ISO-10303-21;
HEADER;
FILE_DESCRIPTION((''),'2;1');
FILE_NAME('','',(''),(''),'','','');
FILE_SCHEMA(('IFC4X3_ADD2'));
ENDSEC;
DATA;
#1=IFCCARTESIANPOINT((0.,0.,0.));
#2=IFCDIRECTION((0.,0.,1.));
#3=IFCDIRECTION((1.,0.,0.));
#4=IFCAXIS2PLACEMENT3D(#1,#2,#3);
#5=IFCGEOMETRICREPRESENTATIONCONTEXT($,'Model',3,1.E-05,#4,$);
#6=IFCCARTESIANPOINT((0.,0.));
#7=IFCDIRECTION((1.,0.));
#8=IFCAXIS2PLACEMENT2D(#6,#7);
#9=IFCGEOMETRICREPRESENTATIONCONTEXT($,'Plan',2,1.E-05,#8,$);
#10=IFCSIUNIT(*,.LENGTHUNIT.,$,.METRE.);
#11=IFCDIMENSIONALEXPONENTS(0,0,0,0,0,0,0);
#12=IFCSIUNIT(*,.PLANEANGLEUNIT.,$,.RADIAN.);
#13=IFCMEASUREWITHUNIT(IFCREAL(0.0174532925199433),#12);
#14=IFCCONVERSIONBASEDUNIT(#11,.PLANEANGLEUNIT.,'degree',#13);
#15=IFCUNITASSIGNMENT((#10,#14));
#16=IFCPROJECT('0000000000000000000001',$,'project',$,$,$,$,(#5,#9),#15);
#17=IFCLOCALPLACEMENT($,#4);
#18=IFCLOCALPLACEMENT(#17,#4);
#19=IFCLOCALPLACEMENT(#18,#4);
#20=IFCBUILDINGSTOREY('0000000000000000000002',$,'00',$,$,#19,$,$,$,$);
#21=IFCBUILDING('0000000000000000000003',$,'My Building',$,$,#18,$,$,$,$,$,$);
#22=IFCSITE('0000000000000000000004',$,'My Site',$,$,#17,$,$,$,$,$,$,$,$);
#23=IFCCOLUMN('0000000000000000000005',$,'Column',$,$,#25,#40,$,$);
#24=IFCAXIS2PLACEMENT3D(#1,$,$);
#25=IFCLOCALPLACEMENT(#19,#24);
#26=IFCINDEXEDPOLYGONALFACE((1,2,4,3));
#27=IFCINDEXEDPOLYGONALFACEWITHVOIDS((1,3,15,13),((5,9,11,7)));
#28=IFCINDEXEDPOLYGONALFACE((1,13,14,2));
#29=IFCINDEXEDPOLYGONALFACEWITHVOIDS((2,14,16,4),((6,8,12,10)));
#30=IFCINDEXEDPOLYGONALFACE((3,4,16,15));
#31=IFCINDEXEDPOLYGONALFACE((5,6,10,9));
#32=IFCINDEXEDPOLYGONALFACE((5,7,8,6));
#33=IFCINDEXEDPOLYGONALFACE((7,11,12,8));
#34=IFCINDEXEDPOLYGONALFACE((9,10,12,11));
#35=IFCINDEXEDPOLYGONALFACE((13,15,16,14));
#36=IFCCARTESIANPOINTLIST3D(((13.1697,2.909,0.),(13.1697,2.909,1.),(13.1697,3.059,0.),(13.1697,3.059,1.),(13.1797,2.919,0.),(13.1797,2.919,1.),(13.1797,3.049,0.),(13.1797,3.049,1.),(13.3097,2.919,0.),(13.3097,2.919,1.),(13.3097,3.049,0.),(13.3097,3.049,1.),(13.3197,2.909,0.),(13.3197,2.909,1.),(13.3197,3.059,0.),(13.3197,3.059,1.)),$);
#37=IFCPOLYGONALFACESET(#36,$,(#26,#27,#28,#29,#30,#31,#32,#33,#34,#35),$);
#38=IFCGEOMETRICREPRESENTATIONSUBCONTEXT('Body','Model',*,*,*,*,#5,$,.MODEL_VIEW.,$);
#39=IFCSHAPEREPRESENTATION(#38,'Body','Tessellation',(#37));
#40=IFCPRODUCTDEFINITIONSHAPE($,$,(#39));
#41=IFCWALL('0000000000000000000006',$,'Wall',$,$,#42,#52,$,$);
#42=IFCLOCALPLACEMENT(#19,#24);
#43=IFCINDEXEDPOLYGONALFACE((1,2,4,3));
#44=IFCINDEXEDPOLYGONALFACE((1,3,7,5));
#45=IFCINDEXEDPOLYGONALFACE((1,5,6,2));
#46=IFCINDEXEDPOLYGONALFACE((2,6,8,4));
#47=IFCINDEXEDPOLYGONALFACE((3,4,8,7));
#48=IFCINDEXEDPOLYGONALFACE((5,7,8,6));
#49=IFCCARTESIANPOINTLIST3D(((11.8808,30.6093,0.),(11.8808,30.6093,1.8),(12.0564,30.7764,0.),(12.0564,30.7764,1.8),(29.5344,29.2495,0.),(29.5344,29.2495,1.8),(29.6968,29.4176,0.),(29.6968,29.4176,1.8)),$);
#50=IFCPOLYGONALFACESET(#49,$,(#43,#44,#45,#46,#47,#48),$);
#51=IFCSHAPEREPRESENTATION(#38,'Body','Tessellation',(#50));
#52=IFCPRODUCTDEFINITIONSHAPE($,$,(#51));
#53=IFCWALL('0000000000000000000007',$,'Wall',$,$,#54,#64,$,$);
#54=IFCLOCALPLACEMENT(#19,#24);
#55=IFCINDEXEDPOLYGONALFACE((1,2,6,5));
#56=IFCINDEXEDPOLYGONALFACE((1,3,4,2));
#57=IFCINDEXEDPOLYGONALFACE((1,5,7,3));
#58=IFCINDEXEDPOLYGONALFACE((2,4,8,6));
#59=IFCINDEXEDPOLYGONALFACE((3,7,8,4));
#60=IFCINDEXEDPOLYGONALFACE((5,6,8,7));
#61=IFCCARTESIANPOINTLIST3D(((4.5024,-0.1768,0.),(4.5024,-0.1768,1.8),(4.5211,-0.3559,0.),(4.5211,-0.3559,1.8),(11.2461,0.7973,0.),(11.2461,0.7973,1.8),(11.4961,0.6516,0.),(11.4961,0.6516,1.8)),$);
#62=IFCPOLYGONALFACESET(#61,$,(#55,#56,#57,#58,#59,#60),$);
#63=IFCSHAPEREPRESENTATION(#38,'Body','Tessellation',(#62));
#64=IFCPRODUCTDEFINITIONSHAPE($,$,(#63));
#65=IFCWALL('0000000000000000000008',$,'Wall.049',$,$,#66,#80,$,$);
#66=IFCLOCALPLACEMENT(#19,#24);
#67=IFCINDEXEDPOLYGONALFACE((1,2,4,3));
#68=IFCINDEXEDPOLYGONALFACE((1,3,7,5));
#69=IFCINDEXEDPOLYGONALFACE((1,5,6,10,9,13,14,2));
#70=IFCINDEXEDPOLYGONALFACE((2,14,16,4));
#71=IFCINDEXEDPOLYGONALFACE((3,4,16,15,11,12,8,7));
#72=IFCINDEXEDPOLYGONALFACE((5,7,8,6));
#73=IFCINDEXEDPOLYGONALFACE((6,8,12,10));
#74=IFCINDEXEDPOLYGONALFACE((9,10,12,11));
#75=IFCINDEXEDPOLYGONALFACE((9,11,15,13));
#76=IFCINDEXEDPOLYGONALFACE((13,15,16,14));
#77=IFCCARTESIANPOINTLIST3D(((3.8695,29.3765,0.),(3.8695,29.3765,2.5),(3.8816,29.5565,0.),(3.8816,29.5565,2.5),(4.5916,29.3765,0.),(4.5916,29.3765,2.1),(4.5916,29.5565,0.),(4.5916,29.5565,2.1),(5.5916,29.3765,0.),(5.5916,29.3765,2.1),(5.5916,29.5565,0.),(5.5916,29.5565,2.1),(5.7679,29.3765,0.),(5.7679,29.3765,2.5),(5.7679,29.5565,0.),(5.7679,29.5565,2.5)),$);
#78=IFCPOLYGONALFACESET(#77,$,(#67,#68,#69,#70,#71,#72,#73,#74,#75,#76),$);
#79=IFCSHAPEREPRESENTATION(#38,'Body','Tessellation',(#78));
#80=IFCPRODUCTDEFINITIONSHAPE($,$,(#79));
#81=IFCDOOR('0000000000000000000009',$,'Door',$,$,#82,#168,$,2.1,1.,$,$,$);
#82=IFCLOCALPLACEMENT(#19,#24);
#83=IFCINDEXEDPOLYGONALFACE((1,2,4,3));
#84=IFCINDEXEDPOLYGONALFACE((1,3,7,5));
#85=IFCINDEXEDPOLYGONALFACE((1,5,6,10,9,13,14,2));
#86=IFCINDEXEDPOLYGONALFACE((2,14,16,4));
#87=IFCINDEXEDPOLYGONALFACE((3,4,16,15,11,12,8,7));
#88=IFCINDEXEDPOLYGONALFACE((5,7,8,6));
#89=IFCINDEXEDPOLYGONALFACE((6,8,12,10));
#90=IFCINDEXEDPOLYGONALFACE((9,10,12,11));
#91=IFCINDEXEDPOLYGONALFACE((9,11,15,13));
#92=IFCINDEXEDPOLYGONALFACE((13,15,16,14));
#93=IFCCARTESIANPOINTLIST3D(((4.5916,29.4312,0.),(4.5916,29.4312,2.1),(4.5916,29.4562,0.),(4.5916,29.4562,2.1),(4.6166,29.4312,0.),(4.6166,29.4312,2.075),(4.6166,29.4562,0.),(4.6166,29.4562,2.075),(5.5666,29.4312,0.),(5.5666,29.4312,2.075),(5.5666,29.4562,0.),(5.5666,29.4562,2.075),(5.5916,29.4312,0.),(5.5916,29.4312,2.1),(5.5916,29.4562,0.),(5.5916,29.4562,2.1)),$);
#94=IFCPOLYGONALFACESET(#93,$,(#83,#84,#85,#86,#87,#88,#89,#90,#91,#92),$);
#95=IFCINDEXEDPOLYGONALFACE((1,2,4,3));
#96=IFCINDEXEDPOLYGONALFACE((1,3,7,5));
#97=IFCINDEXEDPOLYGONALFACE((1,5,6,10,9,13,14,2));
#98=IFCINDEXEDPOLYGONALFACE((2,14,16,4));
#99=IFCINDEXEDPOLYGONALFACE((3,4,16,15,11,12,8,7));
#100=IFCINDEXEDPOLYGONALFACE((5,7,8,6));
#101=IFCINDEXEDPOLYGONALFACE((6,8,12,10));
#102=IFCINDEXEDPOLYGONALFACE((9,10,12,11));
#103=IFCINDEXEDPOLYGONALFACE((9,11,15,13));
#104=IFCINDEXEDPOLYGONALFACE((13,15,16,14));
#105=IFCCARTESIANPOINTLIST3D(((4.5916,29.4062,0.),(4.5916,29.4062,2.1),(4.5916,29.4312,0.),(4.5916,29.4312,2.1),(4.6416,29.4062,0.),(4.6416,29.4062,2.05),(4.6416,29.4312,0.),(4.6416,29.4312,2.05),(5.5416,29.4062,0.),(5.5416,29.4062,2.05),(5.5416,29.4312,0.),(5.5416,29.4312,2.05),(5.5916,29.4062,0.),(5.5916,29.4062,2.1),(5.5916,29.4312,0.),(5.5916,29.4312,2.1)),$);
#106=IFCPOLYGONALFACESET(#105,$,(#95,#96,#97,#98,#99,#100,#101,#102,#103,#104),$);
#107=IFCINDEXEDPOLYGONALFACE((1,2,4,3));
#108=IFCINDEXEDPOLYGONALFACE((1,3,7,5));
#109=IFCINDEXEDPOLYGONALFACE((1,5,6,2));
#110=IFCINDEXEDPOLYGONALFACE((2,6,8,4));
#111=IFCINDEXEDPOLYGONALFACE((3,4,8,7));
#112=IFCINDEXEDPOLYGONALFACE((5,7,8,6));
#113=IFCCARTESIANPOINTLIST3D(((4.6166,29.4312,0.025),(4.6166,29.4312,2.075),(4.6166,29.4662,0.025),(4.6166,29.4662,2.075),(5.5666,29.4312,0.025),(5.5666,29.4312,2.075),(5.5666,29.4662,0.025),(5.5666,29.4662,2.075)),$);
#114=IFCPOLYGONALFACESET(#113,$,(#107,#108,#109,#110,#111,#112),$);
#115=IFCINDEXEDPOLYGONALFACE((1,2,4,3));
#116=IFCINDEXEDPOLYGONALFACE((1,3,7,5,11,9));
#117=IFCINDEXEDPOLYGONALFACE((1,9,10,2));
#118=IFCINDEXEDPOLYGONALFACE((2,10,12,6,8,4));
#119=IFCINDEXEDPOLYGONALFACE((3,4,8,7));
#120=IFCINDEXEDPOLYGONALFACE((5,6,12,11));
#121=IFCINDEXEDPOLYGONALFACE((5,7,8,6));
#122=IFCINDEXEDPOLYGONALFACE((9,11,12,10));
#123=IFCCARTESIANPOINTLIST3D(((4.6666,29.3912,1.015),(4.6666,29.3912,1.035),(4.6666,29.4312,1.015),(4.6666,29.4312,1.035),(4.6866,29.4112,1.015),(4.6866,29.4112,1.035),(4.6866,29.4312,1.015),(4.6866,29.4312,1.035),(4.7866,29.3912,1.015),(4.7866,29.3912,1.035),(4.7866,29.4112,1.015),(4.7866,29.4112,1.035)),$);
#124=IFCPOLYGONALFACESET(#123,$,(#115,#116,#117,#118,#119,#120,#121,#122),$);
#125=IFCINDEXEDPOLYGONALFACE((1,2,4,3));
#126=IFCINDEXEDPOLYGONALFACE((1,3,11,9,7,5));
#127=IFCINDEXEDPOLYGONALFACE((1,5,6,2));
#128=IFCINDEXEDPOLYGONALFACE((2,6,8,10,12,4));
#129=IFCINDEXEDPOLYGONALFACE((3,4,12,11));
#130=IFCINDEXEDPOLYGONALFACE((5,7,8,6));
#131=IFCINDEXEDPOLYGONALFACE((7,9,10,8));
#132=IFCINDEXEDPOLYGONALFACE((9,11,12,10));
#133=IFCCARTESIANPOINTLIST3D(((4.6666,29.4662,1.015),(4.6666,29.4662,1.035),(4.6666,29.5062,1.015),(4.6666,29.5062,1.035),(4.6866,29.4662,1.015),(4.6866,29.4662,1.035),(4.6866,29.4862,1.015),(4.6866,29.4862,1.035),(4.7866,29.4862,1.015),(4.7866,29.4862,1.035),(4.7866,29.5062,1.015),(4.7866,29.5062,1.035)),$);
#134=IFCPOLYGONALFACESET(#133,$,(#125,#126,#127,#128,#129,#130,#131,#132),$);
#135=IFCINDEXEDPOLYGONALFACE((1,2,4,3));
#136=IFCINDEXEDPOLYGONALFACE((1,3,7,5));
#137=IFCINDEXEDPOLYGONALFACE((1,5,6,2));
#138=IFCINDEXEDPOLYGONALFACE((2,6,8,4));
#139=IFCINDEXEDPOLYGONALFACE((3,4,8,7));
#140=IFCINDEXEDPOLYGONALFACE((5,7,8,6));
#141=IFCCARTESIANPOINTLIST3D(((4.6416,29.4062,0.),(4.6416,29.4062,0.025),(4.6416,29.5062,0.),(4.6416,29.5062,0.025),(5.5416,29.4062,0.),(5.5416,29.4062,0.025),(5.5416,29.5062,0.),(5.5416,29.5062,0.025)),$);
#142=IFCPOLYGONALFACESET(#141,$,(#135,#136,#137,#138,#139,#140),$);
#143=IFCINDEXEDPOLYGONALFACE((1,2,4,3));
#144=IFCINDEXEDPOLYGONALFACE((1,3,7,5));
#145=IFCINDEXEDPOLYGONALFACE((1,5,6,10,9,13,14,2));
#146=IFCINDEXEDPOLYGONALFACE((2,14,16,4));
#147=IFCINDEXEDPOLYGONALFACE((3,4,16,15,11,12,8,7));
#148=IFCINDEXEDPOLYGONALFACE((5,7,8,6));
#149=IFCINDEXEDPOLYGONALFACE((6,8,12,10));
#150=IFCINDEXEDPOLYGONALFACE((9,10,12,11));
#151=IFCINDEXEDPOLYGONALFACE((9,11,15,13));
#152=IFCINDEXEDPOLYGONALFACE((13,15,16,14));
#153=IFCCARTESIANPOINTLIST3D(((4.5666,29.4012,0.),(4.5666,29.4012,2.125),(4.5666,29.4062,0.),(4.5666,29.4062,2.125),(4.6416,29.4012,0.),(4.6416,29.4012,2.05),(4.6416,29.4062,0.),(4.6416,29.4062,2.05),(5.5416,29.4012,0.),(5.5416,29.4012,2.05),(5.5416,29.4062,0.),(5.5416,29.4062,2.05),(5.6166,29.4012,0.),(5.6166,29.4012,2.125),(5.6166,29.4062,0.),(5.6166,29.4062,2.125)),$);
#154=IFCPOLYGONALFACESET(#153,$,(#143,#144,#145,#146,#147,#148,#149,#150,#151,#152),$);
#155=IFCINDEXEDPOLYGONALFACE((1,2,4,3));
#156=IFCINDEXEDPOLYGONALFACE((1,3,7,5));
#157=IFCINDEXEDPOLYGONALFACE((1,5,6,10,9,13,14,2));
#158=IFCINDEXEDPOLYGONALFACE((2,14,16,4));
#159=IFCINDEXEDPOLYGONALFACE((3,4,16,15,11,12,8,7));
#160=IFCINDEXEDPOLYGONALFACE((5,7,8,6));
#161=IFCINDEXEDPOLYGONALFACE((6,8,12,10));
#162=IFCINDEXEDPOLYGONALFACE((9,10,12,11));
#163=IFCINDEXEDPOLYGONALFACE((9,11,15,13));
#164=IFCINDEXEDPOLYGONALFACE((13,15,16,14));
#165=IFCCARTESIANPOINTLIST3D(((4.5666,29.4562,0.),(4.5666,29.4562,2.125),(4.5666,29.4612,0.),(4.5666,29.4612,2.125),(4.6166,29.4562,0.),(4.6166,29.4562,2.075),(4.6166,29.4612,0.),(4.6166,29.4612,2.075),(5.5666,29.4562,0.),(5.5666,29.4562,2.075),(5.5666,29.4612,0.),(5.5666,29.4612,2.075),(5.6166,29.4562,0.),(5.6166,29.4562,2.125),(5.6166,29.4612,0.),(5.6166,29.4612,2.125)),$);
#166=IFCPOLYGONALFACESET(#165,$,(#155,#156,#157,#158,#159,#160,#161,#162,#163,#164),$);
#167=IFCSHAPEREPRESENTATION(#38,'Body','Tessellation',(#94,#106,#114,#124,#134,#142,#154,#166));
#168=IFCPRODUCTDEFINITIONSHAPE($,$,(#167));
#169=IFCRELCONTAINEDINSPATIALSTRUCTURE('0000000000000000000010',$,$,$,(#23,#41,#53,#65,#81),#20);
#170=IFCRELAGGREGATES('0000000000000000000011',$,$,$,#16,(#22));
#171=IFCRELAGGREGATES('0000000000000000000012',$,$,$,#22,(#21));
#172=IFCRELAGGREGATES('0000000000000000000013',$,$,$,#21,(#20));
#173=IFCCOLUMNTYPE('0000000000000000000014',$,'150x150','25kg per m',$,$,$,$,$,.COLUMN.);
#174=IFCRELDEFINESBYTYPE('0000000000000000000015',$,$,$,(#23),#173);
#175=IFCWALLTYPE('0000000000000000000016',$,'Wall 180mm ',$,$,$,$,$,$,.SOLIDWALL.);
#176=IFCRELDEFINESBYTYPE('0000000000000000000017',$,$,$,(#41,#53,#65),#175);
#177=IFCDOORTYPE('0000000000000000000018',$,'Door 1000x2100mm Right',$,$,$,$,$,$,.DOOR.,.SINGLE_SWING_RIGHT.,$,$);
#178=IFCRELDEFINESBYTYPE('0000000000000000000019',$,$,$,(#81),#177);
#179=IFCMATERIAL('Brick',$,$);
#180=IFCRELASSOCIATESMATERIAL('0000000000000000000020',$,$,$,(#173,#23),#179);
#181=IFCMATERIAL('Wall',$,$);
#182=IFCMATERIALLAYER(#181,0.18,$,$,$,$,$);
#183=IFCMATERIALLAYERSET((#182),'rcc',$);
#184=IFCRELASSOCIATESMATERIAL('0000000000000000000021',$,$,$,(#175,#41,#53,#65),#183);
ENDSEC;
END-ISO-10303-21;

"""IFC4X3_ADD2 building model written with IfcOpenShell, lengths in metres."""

from ifc_helpers import new_model, entity, si_unit, converted_unit, frame, origin_with_axes, origin_2d_with_axis, place, context, subcontext, project, spatial, line, indexed_curve, hollow_rectangle, outline, extrude, clip, halfspace, shape, source, transform, mapped, material, layer, layer_set, layer_usage, material_profile, profile_set, profile_usage, type_object, type_shapes, element, fill, save


model = new_model("IFC4X3_ADD2")

# Units and contexts
model_context = context("Model", 3, precision=1e-05, world=origin_with_axes())
plan_context = context("Plan", 2, precision=1e-05, world=origin_2d_with_axis())
body_context_1 = subcontext(model_context, "Body", "Model", "MODEL_VIEW")
body_context_2 = subcontext(plan_context, "Body", "Plan", "PLAN_VIEW")
ifc_project = project(units=[si_unit("LENGTHUNIT", "METRE"), converted_unit("PLANEANGLEUNIT", "degree", entity("IfcReal", 0.0174532925199433), si_unit("PLANEANGLEUNIT", "RADIAN"), dimensions=[0, 0, 0, 0, 0, 0, 0])], contexts=[model_context, plan_context])

# Site, building, storey
site_placement = place(None, origin_with_axes())
site = spatial("IfcSite", under=ifc_project, at=site_placement, Name="My Site")
building_placement = place(site_placement, origin_with_axes())
building = spatial("IfcBuilding", under=site, at=building_placement, Name="My Building")
storey_placement = place(building_placement, origin_with_axes())
storey = spatial("IfcBuildingStorey", under=building, at=storey_placement, Name="00")

# Column
ifc_material_1 = material(Name="Brick")
ifc_material_profile = material_profile(ifc_material_1, hollow_rectangle(XDim=0.15, YDim=0.15, WallThickness=0.01))
ifc_profile_set = profile_set([ifc_material_profile])
ifc_profile_usage = profile_usage(ifc_profile_set, cardinal=5)
column_type = type_object("IfcColumnType", Name="150x150", Description="25kg per m", PredefinedType="COLUMN", material=ifc_profile_set)
column_placement = place(storey_placement, frame((13.2447, 2.984, 0.0), z_axis=(0.0, 0.0, 1.0), x_axis=(1.0, 0.0, 0.0)))
element("IfcColumn", 1, at=column_placement, inside=storey, type_object=column_type, material=ifc_profile_usage, Name="Column", shapes=[
    shape(body_context_1, "Body", "SweptSolid", [extrude(hollow_rectangle(XDim=0.15, YDim=0.15, WallThickness=0.01), origin_with_axes(), (0.0, 0.0, 1.0), 1.0)]),
    shape(body_context_2, "Body", "Annotation2D", [entity("IfcGeometricCurveSet", [entity("IfcIndexedPolyCurve", entity("IfcCartesianPointList2D", [[-0.065, -0.065], [-0.065, 0.065], [0.065, 0.065], [0.065, -0.065]]), [entity("IfcLineIndex", [1, 2, 3, 4, 1])]), entity("IfcIndexedPolyCurve", entity("IfcCartesianPointList2D", [[0.075, -0.075], [-0.075, -0.075], [-0.075, 0.075], [0.075, 0.075]]), [entity("IfcLineIndex", [1, 2, 3, 4, 1])])])]),
])

# Walls
ifc_material_2 = material(Name="Wall")
ifc_layer_1 = layer(ifc_material_2, 0.18)
ifc_layer_set_1 = layer_set([ifc_layer_1], Name="rcc")
wall_type_1 = type_object("IfcWallType", Name="Wall 180mm ", PredefinedType="SOLIDWALL", material=ifc_layer_set_1)
ifc_layer_usage_1 = layer_usage(ifc_layer_set_1, "AXIS2", "POSITIVE", 0.0)
wall_1_placement = place(storey_placement, frame((29.6968, 29.4176, 0.0), z_axis=(0.0, 0.0, 1.0), x_axis=(-0.997047, 0.076799, 0.0)))
element("IfcWall", 2, at=wall_1_placement, inside=storey, type_object=wall_type_1, material=ifc_layer_usage_1, Name="Wall", context=body_context_1, shape_type="SweptSolid", body=[
    extrude(outline(indexed_curve([(0.0, 0.0), (0.149, 0.18), (17.8549, 0.18), (17.6927, 0.0)], segments=[line(1, 2, 3, 4, 1)])), origin_with_axes(), (0.0, 0.0, 1.0), 1.8),
])
ifc_layer_usage_2 = layer_usage(ifc_layer_set_1, "AXIS2", "POSITIVE", 0.0)
wall_2_placement = place(storey_placement, frame((4.5211, -0.3559, 0.0), z_axis=(0.0, 0.0, 1.0), x_axis=(0.989728, 0.142965, 0.0)))
element("IfcWall", 3, at=wall_2_placement, inside=storey, type_object=wall_type_1, material=ifc_layer_usage_2, Name="Wall", context=body_context_1, shape_type="SweptSolid", body=[
    extrude(outline(indexed_curve([(0.0, 0.0), (0.007, 0.18), (6.8207, 0.18), (7.0473, 0.0)], segments=[line(1, 2, 3, 4, 1)])), origin_with_axes(), (0.0, 0.0, 1.0), 1.8),
])

# Wall, opening, door
ifc_layer_usage_3 = layer_usage(ifc_layer_set_1, "AXIS2", "POSITIVE", 0.0)
wall_3_placement = place(storey_placement, frame((3.8695, 29.3765, 0.0), z_axis=(0.0, 0.0, 1.0), x_axis=(1.0, 0.0, 0.0)))
wall_3 = element("IfcWall", 4, at=wall_3_placement, inside=storey, type_object=wall_type_1, material=ifc_layer_usage_3, Name="Wall.049", context=body_context_1, shape_type="Clipping", body=[
    clip(extrude(outline(indexed_curve([(0.0, 0.0), (0.0, 0.18), (1.8985, 0.18), (1.8985, 0.0), (0.0, 0.0)], self_intersect=False)), origin_with_axes(), (0.0, 0.0, 1.0), 2.5), halfspace(frame((0.0, 0.0, 0.0), z_axis=(-0.324001, 0.021894, 0.0), x_axis=(0.067419, 0.997725, 0.0)), False)),
])
shared_shape_1 = source(origin_with_axes(), body_context_1, "Body", "SweptSolid", [
    extrude(outline(indexed_curve([(0.0, 0.0), (1.0, 0.0), (1.0, 2.1), (0.0, 2.1)], segments=[line(1, 2, 3, 4, 1)])), frame((0.0, -0.6, 0.0), z_axis=(0.0, -1.0, 0.0), x_axis=(1.0, 0.0, 0.0)), (0.0, 0.0, -1.0), 1.2),
])
opening_1_placement = place(wall_3_placement, frame((0.7221, 0.0298, 0.0), z_axis=(0.0, 0.0, 1.0), x_axis=(1.0, 0.0, 0.0)))
opening_1 = element("IfcOpeningElement", 5, at=opening_1_placement, cuts=wall_3, PredefinedType="OPENING", context=body_context_1, shape_type="MappedRepresentation", body=[
    mapped(shared_shape_1, transform((0.0, 0.0, 0.0), x_axis=(1.0, 0.0, 0.0), y_axis=(0.0, 1.0, 0.0), z_axis=(0.0, 0.0, 1.0), scale=1.0)),
])
door_type_1 = type_object("IfcDoorType", Name="Door 1000x2100mm Right", OperationType="SINGLE_SWING_RIGHT", PredefinedType="DOOR")
shared_shape_2 = source(origin_with_axes(), body_context_1, "Body", "SweptSolid", [
    extrude(outline(indexed_curve([(0.0, 0.0), (0.0, 2.1), (1.0, 2.1), (1.0, 0.0), (0.975, 0.0), (0.975, 2.075), (0.025, 2.075), (0.025, 0.0)], segments=[line(1, 2, 3, 4, 5, 6, 7, 8, 1)])), frame((0.0, 0.025, 0.0), z_axis=(0.0, -1.0, 0.0), x_axis=(1.0, 0.0, 0.0)), (0.0, 0.0, -1.0), 0.025),
    extrude(outline(indexed_curve([(0.0, 0.0), (0.0, 2.1), (1.0, 2.1), (1.0, 0.0), (0.95, 0.0), (0.95, 2.05), (0.05, 2.05), (0.05, 0.0)], segments=[line(1, 2, 3, 4, 5, 6, 7, 8, 1)])), frame((0.0, 0.0, 0.0), z_axis=(0.0, -1.0, 0.0), x_axis=(1.0, 0.0, 0.0)), (0.0, 0.0, -1.0), 0.025),
    extrude(outline(indexed_curve([(0.0, 0.0), (0.95, 0.0), (0.95, 0.035), (0.0, 0.035)], segments=[line(1, 2, 3, 4, 1)])), frame((0.025, 0.025, 0.025), z_axis=(0.0, 0.0, 1.0), x_axis=(1.0, 0.0, 0.0)), (0.0, 0.0, 1.0), 2.05),
    extrude(outline(indexed_curve([(0.0, 0.0), (0.0, -0.04), (0.12, -0.04), (0.12, -0.02), (0.02, -0.02), (0.02, 0.0)], segments=[line(1, 2, 3, 4, 5, 6, 1)])), frame((0.075, 0.025, 1.015), z_axis=(0.0, 0.0, 1.0), x_axis=(1.0, 0.0, 0.0)), (0.0, 0.0, 1.0), 0.02),
    extrude(outline(indexed_curve([(0.0, 0.0), (0.0, 0.04), (0.12, 0.04), (0.12, 0.02), (0.02, 0.02), (0.02, 0.0)], segments=[line(1, 2, 3, 4, 5, 6, 1)])), frame((0.075, 0.06, 1.015), z_axis=(0.0, 0.0, 1.0), x_axis=(1.0, 0.0, 0.0)), (0.0, 0.0, 1.0), 0.02),
    extrude(outline(indexed_curve([(0.0, 0.0), (0.9, 0.0), (0.9, 0.1), (0.0, 0.1)], segments=[line(1, 2, 3, 4, 1)])), frame((0.05, 0.0, 0.0), z_axis=(0.0, 0.0, 1.0), x_axis=(1.0, 0.0, 0.0)), (0.0, 0.0, 1.0), 0.025),
    extrude(outline(indexed_curve([(0.0, 0.0), (0.0, 2.125), (1.05, 2.125), (1.05, 0.0), (0.975, 0.0), (0.975, 2.05), (0.075, 2.05), (0.075, 0.0)], segments=[line(1, 2, 3, 4, 5, 6, 7, 8, 1)])), frame((-0.025, -0.005, 0.0), z_axis=(0.0, -1.0, 0.0), x_axis=(1.0, 0.0, 0.0)), (0.0, 0.0, -1.0), 0.005),
    extrude(outline(indexed_curve([(0.0, 0.0), (0.0, 2.125), (1.05, 2.125), (1.05, 0.0), (1.0, 0.0), (1.0, 2.075), (0.05, 2.075), (0.05, 0.0)], segments=[line(1, 2, 3, 4, 5, 6, 7, 8, 1)])), frame((-0.025, 0.05, 0.0), z_axis=(0.0, -1.0, 0.0), x_axis=(1.0, 0.0, 0.0)), (0.0, 0.0, -1.0), 0.005),
])
shared_shape_3 = source(origin_with_axes(), body_context_2, "Body", "Curve2D", [
    entity("IfcIndexedPolyCurve", entity("IfcCartesianPointList2D", [[0.0, 0.0], [0.0, 0.05], [0.025, 0.05], [0.025, 0.025], [0.05, 0.025], [0.05, 0.0]]), [entity("IfcLineIndex", [1, 2, 3, 4, 5, 6, 1])]),
    entity("IfcIndexedPolyCurve", entity("IfcCartesianPointList2D", [[1.0, 0.0], [1.0, 0.05], [0.975, 0.05], [0.975, 0.025], [0.95, 0.025], [0.95, 0.0]]), [entity("IfcLineIndex", [1, 2, 3, 4, 5, 6, 1])]),
    entity("IfcTrimmedCurve", entity("IfcEllipse", entity("IfcAxis2Placement2D", entity("IfcCartesianPoint", [0.94, 0.05]), entity("IfcDirection", [1.0, 0.0])), 0.915, 0.95), [entity("IfcCartesianPoint", [0.94, 1.0])], [entity("IfcCartesianPoint", [0.025, 0.05])], True, "CARTESIAN"),
    entity("IfcIndexedPolyCurve", entity("IfcCartesianPointList2D", [[0.975, 0.05], [0.94, 0.05], [0.94, 1.0], [0.975, 1.0]]), [entity("IfcLineIndex", [1, 2, 3, 4, 1])]),
])
type_shapes(door_type_1, [shared_shape_2, shared_shape_3])
door_1_placement = place(opening_1_placement, origin_with_axes())
door_1 = element("IfcDoor", 6, at=door_1_placement, inside=storey, type_object=door_type_1, Name="Door", OverallHeight=2.1, OverallWidth=1.0, shapes=[
    shape(body_context_1, "Body", "MappedRepresentation", [mapped(shared_shape_2, transform((0.0, 0.0, 0.0), x_axis=(1.0, 0.0, 0.0), y_axis=(0.0, 1.0, 0.0), z_axis=(0.0, 0.0, 1.0), scale=1.0))]),
    shape(body_context_2, "Body", "MappedRepresentation", [mapped(shared_shape_3, transform((0.0, 0.0, 0.0), x_axis=(1.0, 0.0, 0.0), y_axis=(0.0, 1.0, 0.0), z_axis=(0.0, 0.0, 1.0), scale=1.0))]),
])
fill(opening_1, door_1)

save(model, "model.ifc")
